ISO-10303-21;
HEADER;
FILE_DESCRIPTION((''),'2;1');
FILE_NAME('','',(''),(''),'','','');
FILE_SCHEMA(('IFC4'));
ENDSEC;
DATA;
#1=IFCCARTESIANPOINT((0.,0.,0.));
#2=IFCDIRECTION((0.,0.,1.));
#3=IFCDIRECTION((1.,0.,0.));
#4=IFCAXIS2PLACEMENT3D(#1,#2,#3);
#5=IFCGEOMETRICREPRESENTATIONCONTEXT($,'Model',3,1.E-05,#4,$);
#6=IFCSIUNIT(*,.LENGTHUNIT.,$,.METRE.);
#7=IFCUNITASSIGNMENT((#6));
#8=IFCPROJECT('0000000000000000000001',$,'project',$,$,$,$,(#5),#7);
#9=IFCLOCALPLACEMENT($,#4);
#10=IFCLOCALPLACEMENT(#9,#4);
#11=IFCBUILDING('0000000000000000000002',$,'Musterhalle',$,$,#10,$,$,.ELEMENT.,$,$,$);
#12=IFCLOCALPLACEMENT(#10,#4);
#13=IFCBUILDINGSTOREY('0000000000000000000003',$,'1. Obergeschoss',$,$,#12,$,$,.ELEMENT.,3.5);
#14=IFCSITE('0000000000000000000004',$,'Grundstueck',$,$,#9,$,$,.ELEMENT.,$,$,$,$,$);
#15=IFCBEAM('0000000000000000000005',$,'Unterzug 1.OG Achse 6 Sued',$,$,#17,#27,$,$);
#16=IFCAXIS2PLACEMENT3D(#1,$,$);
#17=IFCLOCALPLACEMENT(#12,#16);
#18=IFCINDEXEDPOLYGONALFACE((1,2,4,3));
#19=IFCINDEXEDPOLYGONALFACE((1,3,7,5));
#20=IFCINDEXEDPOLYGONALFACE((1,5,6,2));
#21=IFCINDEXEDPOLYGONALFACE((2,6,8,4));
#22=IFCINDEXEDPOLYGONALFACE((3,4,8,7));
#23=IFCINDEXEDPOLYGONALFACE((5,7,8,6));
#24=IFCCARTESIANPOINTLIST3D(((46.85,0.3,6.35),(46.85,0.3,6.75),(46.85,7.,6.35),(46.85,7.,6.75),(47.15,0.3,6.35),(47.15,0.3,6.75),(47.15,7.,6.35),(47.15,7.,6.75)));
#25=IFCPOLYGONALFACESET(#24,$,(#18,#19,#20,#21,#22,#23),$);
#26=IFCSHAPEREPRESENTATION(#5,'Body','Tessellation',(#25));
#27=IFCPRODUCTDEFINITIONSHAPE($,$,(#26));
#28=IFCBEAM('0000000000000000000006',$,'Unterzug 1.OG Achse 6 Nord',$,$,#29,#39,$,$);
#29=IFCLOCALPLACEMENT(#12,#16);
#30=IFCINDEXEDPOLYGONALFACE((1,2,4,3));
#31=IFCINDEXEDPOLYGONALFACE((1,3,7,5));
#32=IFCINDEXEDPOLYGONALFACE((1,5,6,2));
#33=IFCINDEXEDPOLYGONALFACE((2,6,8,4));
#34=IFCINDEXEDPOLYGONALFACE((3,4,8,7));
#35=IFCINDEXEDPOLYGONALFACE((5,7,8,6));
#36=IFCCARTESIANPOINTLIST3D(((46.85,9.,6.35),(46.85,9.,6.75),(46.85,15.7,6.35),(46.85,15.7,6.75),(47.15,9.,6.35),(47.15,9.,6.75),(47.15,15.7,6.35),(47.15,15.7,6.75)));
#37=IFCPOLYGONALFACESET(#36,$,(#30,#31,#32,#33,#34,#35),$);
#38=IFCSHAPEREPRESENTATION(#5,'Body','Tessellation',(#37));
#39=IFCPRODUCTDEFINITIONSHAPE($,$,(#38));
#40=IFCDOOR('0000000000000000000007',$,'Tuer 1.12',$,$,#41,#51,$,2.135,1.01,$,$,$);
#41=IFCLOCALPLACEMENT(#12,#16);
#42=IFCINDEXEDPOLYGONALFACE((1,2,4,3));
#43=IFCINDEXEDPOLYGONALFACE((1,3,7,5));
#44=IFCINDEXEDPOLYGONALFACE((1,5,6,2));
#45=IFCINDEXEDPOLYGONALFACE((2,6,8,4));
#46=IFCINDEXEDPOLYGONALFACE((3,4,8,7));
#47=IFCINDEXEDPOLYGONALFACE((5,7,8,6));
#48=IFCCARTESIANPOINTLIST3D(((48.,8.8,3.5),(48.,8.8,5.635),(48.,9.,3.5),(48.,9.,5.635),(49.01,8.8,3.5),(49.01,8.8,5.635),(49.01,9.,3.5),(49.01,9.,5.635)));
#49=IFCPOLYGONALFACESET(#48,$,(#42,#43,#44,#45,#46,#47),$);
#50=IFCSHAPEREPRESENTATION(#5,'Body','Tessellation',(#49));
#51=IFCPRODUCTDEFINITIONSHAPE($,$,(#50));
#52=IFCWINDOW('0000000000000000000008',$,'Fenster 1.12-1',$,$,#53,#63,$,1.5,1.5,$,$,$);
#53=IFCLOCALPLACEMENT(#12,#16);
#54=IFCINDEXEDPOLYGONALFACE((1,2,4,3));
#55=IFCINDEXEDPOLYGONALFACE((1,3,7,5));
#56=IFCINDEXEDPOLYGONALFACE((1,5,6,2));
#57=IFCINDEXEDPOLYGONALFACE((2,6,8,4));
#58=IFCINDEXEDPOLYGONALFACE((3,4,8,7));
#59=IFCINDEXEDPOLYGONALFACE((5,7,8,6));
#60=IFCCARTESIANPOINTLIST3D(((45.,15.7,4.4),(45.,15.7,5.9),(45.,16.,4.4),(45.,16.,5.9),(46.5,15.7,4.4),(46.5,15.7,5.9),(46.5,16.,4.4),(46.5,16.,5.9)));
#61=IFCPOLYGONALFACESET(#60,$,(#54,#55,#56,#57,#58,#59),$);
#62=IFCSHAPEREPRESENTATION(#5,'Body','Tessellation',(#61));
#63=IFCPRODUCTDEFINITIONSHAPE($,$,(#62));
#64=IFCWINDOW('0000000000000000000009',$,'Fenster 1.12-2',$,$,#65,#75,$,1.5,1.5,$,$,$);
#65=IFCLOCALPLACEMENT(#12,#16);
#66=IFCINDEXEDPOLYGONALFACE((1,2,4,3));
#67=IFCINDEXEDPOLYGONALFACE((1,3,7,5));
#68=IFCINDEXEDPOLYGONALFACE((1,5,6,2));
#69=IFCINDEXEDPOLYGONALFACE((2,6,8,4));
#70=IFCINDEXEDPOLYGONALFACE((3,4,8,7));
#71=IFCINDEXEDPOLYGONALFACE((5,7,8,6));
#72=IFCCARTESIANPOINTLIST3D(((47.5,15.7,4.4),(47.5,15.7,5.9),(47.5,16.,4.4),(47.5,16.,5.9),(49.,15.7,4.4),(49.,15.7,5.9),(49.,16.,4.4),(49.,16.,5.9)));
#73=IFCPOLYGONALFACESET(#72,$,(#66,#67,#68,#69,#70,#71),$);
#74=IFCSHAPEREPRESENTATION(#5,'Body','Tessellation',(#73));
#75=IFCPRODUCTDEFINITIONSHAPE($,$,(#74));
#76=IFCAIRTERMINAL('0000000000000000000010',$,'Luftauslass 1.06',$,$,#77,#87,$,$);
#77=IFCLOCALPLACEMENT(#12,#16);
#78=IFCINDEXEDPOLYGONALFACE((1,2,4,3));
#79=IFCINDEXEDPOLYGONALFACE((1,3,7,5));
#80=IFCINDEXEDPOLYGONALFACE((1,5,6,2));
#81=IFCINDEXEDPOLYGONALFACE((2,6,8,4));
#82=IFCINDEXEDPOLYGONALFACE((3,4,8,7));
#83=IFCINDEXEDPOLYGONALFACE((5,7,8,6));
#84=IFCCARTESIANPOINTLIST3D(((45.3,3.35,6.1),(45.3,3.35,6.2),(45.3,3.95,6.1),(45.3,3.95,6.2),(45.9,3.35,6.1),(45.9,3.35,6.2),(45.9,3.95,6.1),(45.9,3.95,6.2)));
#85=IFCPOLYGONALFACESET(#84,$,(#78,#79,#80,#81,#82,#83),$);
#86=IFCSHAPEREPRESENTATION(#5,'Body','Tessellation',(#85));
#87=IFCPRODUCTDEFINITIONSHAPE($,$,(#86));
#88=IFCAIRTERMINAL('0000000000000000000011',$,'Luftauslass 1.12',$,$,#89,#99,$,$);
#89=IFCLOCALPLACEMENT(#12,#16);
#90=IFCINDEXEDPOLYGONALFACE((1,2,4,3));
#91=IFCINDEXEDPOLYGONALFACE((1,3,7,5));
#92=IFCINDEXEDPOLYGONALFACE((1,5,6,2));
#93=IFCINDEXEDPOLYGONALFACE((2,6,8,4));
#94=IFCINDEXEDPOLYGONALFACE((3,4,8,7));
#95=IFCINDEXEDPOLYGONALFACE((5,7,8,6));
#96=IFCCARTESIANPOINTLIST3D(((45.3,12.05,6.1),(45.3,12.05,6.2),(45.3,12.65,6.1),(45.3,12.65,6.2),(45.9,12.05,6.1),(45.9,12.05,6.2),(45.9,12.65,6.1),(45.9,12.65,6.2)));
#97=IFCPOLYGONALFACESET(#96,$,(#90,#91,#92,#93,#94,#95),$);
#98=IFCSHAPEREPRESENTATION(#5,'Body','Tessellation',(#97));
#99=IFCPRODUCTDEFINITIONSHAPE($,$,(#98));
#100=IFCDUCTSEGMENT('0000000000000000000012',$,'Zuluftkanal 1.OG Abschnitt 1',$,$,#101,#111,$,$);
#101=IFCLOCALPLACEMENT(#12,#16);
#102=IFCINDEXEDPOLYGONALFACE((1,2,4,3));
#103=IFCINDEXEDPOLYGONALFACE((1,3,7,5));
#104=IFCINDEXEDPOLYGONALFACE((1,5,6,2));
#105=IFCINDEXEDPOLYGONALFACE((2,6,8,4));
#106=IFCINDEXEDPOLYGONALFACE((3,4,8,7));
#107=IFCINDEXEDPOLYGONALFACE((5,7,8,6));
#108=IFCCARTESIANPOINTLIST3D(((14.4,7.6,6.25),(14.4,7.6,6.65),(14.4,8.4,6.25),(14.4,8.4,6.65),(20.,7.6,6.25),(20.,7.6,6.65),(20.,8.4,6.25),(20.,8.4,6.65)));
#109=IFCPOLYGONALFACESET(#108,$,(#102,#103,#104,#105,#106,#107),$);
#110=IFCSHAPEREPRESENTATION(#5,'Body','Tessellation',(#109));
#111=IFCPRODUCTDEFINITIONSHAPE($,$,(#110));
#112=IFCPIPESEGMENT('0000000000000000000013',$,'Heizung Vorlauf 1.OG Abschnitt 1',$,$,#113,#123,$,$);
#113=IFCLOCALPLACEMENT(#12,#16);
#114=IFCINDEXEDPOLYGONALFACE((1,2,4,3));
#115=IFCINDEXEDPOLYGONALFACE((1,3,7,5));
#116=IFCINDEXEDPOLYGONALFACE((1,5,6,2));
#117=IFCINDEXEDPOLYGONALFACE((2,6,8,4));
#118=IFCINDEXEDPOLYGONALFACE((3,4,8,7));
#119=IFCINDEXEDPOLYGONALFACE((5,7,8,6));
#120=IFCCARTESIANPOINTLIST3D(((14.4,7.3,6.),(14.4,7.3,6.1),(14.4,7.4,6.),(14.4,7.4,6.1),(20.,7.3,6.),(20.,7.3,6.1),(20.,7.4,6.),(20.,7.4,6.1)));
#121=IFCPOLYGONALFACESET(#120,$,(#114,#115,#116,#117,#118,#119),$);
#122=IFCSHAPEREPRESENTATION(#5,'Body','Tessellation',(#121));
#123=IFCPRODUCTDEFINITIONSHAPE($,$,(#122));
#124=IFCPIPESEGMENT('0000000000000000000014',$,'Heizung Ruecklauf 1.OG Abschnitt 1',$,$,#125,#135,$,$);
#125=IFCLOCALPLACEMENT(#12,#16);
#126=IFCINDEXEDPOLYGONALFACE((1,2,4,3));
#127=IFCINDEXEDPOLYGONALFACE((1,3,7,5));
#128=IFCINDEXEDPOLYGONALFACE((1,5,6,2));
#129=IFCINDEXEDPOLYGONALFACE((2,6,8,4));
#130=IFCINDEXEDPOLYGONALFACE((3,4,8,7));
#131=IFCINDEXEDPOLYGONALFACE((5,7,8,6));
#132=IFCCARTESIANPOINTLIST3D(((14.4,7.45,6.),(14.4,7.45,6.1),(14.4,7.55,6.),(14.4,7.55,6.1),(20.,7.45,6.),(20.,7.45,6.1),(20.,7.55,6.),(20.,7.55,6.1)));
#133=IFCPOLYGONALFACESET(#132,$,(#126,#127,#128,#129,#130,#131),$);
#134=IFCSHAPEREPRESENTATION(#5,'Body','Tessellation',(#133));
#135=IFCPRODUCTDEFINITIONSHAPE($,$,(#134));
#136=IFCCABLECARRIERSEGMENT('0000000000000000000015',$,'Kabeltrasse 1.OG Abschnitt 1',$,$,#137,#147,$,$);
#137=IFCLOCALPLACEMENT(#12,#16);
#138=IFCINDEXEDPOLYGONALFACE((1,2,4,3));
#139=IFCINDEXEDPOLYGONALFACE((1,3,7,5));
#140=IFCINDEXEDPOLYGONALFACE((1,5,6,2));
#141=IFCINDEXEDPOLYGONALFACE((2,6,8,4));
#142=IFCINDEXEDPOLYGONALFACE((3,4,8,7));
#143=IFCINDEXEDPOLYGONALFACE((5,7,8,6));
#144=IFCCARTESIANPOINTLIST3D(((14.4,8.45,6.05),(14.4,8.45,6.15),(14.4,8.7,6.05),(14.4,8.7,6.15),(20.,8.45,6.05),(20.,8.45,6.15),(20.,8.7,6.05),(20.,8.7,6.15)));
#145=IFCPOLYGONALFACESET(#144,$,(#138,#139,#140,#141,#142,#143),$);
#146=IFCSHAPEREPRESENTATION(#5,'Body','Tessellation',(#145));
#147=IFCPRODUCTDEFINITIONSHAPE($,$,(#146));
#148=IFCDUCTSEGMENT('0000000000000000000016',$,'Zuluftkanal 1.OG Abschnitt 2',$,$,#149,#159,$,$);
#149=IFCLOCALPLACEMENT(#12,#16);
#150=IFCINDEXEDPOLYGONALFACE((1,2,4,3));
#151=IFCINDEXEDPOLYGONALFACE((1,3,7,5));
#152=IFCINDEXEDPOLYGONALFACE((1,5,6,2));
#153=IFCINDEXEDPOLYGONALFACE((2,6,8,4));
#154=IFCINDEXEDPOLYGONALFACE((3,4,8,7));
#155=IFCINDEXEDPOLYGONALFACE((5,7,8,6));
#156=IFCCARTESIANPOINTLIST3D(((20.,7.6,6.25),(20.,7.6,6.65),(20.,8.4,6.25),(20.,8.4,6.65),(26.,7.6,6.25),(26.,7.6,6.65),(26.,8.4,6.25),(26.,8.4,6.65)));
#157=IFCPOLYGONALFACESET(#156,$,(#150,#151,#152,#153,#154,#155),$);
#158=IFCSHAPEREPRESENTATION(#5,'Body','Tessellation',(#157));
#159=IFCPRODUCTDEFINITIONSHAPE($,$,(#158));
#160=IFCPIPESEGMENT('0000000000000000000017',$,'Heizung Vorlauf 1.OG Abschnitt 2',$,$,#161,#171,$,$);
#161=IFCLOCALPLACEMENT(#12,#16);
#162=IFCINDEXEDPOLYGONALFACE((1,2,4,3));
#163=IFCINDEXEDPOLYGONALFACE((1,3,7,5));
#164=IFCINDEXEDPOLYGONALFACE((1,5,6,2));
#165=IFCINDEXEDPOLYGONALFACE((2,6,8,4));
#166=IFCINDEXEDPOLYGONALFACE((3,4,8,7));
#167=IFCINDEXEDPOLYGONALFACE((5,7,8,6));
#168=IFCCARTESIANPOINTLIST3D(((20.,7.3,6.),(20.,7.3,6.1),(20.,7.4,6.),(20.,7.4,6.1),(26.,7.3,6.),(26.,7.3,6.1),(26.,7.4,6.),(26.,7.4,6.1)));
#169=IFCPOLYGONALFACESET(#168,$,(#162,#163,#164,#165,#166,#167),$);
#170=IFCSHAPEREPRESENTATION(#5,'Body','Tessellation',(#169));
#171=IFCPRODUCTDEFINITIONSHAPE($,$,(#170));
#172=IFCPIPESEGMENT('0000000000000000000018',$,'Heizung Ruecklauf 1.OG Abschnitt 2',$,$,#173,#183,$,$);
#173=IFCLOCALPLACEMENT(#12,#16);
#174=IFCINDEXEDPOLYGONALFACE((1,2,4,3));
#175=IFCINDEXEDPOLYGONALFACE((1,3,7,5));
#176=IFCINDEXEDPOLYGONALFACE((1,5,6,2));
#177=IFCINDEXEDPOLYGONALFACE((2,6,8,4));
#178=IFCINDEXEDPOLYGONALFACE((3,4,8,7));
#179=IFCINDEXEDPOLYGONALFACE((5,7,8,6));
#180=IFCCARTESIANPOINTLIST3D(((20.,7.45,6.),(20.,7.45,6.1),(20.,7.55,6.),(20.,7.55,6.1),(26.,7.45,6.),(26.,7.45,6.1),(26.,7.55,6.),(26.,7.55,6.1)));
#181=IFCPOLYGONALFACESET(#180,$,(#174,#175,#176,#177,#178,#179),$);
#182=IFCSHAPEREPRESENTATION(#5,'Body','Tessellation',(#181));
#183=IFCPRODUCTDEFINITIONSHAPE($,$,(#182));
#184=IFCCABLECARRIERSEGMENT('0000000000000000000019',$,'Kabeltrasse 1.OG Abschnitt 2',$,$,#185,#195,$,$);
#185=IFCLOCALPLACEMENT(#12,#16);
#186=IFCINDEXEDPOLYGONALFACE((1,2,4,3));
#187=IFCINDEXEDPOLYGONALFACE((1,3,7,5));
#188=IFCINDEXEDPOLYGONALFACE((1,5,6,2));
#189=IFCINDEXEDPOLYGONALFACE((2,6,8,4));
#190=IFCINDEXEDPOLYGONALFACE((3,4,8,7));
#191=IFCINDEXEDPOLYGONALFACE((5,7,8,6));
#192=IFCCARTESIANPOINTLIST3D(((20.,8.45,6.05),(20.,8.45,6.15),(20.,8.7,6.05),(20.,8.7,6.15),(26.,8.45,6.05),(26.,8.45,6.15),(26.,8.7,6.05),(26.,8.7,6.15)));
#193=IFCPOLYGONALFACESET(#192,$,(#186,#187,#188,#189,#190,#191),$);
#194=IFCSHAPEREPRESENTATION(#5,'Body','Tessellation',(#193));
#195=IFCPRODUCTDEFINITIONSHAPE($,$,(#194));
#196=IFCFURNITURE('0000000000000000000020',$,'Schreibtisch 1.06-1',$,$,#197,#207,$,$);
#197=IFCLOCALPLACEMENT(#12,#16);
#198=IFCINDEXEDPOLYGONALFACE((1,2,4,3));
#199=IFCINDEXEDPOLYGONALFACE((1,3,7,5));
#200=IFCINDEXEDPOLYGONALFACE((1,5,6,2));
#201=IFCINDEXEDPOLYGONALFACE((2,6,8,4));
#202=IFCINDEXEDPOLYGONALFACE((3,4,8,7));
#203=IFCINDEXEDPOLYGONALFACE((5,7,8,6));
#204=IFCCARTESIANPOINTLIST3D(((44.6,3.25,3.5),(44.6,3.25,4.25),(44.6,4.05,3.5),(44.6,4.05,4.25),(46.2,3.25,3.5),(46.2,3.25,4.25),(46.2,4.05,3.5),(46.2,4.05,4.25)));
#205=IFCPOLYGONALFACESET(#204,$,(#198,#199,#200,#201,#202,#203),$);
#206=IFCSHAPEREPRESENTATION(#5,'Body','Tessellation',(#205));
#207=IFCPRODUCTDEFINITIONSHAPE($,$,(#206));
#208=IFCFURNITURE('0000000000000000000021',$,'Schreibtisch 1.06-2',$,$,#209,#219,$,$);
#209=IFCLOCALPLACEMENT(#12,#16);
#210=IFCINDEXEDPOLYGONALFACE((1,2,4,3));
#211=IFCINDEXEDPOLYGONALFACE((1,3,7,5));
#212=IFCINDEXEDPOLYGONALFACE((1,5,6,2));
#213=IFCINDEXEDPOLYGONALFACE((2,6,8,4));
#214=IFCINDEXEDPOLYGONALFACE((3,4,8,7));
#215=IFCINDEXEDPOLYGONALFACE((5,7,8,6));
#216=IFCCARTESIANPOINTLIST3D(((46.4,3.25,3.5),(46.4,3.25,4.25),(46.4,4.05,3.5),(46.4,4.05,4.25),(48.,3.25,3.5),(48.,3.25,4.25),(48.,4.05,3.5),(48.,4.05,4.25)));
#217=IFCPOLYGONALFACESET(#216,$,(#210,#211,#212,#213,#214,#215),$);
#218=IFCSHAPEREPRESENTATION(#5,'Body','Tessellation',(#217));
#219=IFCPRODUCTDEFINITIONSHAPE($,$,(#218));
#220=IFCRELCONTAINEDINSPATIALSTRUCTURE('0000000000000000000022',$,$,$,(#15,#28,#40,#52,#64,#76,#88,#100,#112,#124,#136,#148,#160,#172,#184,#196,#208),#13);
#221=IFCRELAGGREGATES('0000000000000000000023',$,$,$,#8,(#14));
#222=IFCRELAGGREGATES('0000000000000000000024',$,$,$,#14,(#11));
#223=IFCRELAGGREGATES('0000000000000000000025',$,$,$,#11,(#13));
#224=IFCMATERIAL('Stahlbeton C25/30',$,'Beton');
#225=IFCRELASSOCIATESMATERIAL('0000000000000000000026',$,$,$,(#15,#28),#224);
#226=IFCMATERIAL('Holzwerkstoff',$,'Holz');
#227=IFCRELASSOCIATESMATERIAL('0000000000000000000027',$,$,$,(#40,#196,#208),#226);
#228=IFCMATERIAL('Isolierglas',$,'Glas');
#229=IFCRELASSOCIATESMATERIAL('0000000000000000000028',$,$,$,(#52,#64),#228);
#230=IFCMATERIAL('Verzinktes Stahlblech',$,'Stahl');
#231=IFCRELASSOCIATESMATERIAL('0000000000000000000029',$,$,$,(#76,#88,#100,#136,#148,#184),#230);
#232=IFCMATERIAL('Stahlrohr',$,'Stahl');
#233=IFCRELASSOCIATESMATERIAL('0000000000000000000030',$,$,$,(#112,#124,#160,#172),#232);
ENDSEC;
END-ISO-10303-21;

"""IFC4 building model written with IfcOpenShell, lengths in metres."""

from ifc_helpers import new_model, si_unit, frame, origin_with_axes, origin_2d, place, context, project, spatial, rectangle, extrude, material, element, save


model = new_model("IFC4")

# Units and contexts
model_context = context("Model", 3, precision=1e-05, world=origin_with_axes())
ifc_project = project(units=[si_unit("LENGTHUNIT", "METRE")], contexts=[model_context])

# Site, building, storey
site_placement = place(None, origin_with_axes())
site = spatial("IfcSite", under=ifc_project, at=site_placement, Name="Grundstueck", CompositionType="ELEMENT")
building_placement = place(site_placement, origin_with_axes())
building = spatial("IfcBuilding", under=site, at=building_placement, Name="Musterhalle", CompositionType="ELEMENT")
storey_placement = place(building_placement, origin_with_axes())
storey = spatial("IfcBuildingStorey", under=building, at=storey_placement, Name="1. Obergeschoss", CompositionType="ELEMENT", Elevation=3.5)

# Beams
ifc_material_1 = material(Name="Stahlbeton C25/30", Category="Beton")
placement = place(storey_placement, origin_with_axes())
element("IfcBeam", 1, at=placement, inside=storey, material=ifc_material_1, Name="Unterzug 1.OG Achse 6 Sued", context=model_context, shape_type="SweptSolid", body=[
    extrude(rectangle(XDim=0.3, YDim=6.7, at=origin_2d()), frame((47.0, 3.65, 6.35), z_axis=(0.0, 0.0, 1.0), x_axis=(1.0, 0.0, 0.0)), (0.0, 0.0, 1.0), 0.4),
])
element("IfcBeam", 2, at=placement, inside=storey, material=ifc_material_1, Name="Unterzug 1.OG Achse 6 Nord", context=model_context, shape_type="SweptSolid", body=[
    extrude(rectangle(XDim=0.3, YDim=6.7, at=origin_2d()), frame((47.0, 12.35, 6.35), z_axis=(0.0, 0.0, 1.0), x_axis=(1.0, 0.0, 0.0)), (0.0, 0.0, 1.0), 0.4),
])

# Door
ifc_material_2 = material(Name="Holzwerkstoff", Category="Holz")
element("IfcDoor", 3, at=placement, inside=storey, material=ifc_material_2, Name="Tuer 1.12", OverallHeight=2.135, OverallWidth=1.01, context=model_context, shape_type="SweptSolid", body=[
    extrude(rectangle(XDim=1.01, YDim=0.2, at=origin_2d()), frame((48.505, 8.9, 3.5), z_axis=(0.0, 0.0, 1.0), x_axis=(1.0, 0.0, 0.0)), (0.0, 0.0, 1.0), 2.135),
])

# Windows
ifc_material_3 = material(Name="Isolierglas", Category="Glas")
element("IfcWindow", 4, at=placement, inside=storey, material=ifc_material_3, Name="Fenster 1.12-1", OverallHeight=1.5, OverallWidth=1.5, context=model_context, shape_type="SweptSolid", body=[
    extrude(rectangle(XDim=1.5, YDim=0.3, at=origin_2d()), frame((45.75, 15.85, 4.4), z_axis=(0.0, 0.0, 1.0), x_axis=(1.0, 0.0, 0.0)), (0.0, 0.0, 1.0), 1.5),
])
element("IfcWindow", 5, at=placement, inside=storey, material=ifc_material_3, Name="Fenster 1.12-2", OverallHeight=1.5, OverallWidth=1.5, context=model_context, shape_type="SweptSolid", body=[
    extrude(rectangle(XDim=1.5, YDim=0.3, at=origin_2d()), frame((48.25, 15.85, 4.4), z_axis=(0.0, 0.0, 1.0), x_axis=(1.0, 0.0, 0.0)), (0.0, 0.0, 1.0), 1.5),
])

# Air terminals
ifc_material_4 = material(Name="Verzinktes Stahlblech", Category="Stahl")
element("IfcAirTerminal", 6, at=placement, inside=storey, material=ifc_material_4, Name="Luftauslass 1.06", context=model_context, shape_type="SweptSolid", body=[
    extrude(rectangle(XDim=0.6, YDim=0.6, at=origin_2d()), frame((45.6, 3.65, 6.1), z_axis=(0.0, 0.0, 1.0), x_axis=(1.0, 0.0, 0.0)), (0.0, 0.0, 1.0), 0.1),
])
element("IfcAirTerminal", 7, at=placement, inside=storey, material=ifc_material_4, Name="Luftauslass 1.12", context=model_context, shape_type="SweptSolid", body=[
    extrude(rectangle(XDim=0.6, YDim=0.6, at=origin_2d()), frame((45.6, 12.35, 6.1), z_axis=(0.0, 0.0, 1.0), x_axis=(1.0, 0.0, 0.0)), (0.0, 0.0, 1.0), 0.1),
])

# Duct segment
element("IfcDuctSegment", 8, at=placement, inside=storey, material=ifc_material_4, Name="Zuluftkanal 1.OG Abschnitt 1", context=model_context, shape_type="SweptSolid", body=[
    extrude(rectangle(XDim=5.6, YDim=0.8, at=origin_2d()), frame((17.2, 8.0, 6.25), z_axis=(0.0, 0.0, 1.0), x_axis=(1.0, 0.0, 0.0)), (0.0, 0.0, 1.0), 0.4),
])

# Pipe segments
ifc_material_5 = material(Name="Stahlrohr", Category="Stahl")
element("IfcPipeSegment", 9, at=placement, inside=storey, material=ifc_material_5, Name="Heizung Vorlauf 1.OG Abschnitt 1", context=model_context, shape_type="SweptSolid", body=[
    extrude(rectangle(XDim=5.6, YDim=0.1, at=origin_2d()), frame((17.2, 7.35, 6.0), z_axis=(0.0, 0.0, 1.0), x_axis=(1.0, 0.0, 0.0)), (0.0, 0.0, 1.0), 0.1),
])
element("IfcPipeSegment", 10, at=placement, inside=storey, material=ifc_material_5, Name="Heizung Ruecklauf 1.OG Abschnitt 1", context=model_context, shape_type="SweptSolid", body=[
    extrude(rectangle(XDim=5.6, YDim=0.1, at=origin_2d()), frame((17.2, 7.5, 6.0), z_axis=(0.0, 0.0, 1.0), x_axis=(1.0, 0.0, 0.0)), (0.0, 0.0, 1.0), 0.1),
])

# Cable carrier segment
element("IfcCableCarrierSegment", 11, at=placement, inside=storey, material=ifc_material_4, Name="Kabeltrasse 1.OG Abschnitt 1", context=model_context, shape_type="SweptSolid", body=[
    extrude(rectangle(XDim=5.6, YDim=0.25, at=origin_2d()), frame((17.2, 8.575, 6.05), z_axis=(0.0, 0.0, 1.0), x_axis=(1.0, 0.0, 0.0)), (0.0, 0.0, 1.0), 0.1),
])

# Duct segment
element("IfcDuctSegment", 12, at=placement, inside=storey, material=ifc_material_4, Name="Zuluftkanal 1.OG Abschnitt 2", context=model_context, shape_type="SweptSolid", body=[
    extrude(rectangle(XDim=6.0, YDim=0.8, at=origin_2d()), frame((23.0, 8.0, 6.25), z_axis=(0.0, 0.0, 1.0), x_axis=(1.0, 0.0, 0.0)), (0.0, 0.0, 1.0), 0.4),
])

# Pipe segments
element("IfcPipeSegment", 13, at=placement, inside=storey, material=ifc_material_5, Name="Heizung Vorlauf 1.OG Abschnitt 2", context=model_context, shape_type="SweptSolid", body=[
    extrude(rectangle(XDim=6.0, YDim=0.1, at=origin_2d()), frame((23.0, 7.35, 6.0), z_axis=(0.0, 0.0, 1.0), x_axis=(1.0, 0.0, 0.0)), (0.0, 0.0, 1.0), 0.1),
])
element("IfcPipeSegment", 14, at=placement, inside=storey, material=ifc_material_5, Name="Heizung Ruecklauf 1.OG Abschnitt 2", context=model_context, shape_type="SweptSolid", body=[
    extrude(rectangle(XDim=6.0, YDim=0.1, at=origin_2d()), frame((23.0, 7.5, 6.0), z_axis=(0.0, 0.0, 1.0), x_axis=(1.0, 0.0, 0.0)), (0.0, 0.0, 1.0), 0.1),
])

# Cable carrier segment
element("IfcCableCarrierSegment", 15, at=placement, inside=storey, material=ifc_material_4, Name="Kabeltrasse 1.OG Abschnitt 2", context=model_context, shape_type="SweptSolid", body=[
    extrude(rectangle(XDim=6.0, YDim=0.25, at=origin_2d()), frame((23.0, 8.575, 6.05), z_axis=(0.0, 0.0, 1.0), x_axis=(1.0, 0.0, 0.0)), (0.0, 0.0, 1.0), 0.1),
])

# Furniture
element("IfcFurniture", 16, at=placement, inside=storey, material=ifc_material_2, Name="Schreibtisch 1.06-1", context=model_context, shape_type="SweptSolid", body=[
    extrude(rectangle(XDim=1.6, YDim=0.8, at=origin_2d()), frame((45.4, 3.65, 3.5), z_axis=(0.0, 0.0, 1.0), x_axis=(1.0, 0.0, 0.0)), (0.0, 0.0, 1.0), 0.75),
])
element("IfcFurniture", 17, at=placement, inside=storey, material=ifc_material_2, Name="Schreibtisch 1.06-2", context=model_context, shape_type="SweptSolid", body=[
    extrude(rectangle(XDim=1.6, YDim=0.8, at=origin_2d()), frame((47.2, 3.65, 3.5), z_axis=(0.0, 0.0, 1.0), x_axis=(1.0, 0.0, 0.0)), (0.0, 0.0, 1.0), 0.75),
])

save(model, "model.ifc")
